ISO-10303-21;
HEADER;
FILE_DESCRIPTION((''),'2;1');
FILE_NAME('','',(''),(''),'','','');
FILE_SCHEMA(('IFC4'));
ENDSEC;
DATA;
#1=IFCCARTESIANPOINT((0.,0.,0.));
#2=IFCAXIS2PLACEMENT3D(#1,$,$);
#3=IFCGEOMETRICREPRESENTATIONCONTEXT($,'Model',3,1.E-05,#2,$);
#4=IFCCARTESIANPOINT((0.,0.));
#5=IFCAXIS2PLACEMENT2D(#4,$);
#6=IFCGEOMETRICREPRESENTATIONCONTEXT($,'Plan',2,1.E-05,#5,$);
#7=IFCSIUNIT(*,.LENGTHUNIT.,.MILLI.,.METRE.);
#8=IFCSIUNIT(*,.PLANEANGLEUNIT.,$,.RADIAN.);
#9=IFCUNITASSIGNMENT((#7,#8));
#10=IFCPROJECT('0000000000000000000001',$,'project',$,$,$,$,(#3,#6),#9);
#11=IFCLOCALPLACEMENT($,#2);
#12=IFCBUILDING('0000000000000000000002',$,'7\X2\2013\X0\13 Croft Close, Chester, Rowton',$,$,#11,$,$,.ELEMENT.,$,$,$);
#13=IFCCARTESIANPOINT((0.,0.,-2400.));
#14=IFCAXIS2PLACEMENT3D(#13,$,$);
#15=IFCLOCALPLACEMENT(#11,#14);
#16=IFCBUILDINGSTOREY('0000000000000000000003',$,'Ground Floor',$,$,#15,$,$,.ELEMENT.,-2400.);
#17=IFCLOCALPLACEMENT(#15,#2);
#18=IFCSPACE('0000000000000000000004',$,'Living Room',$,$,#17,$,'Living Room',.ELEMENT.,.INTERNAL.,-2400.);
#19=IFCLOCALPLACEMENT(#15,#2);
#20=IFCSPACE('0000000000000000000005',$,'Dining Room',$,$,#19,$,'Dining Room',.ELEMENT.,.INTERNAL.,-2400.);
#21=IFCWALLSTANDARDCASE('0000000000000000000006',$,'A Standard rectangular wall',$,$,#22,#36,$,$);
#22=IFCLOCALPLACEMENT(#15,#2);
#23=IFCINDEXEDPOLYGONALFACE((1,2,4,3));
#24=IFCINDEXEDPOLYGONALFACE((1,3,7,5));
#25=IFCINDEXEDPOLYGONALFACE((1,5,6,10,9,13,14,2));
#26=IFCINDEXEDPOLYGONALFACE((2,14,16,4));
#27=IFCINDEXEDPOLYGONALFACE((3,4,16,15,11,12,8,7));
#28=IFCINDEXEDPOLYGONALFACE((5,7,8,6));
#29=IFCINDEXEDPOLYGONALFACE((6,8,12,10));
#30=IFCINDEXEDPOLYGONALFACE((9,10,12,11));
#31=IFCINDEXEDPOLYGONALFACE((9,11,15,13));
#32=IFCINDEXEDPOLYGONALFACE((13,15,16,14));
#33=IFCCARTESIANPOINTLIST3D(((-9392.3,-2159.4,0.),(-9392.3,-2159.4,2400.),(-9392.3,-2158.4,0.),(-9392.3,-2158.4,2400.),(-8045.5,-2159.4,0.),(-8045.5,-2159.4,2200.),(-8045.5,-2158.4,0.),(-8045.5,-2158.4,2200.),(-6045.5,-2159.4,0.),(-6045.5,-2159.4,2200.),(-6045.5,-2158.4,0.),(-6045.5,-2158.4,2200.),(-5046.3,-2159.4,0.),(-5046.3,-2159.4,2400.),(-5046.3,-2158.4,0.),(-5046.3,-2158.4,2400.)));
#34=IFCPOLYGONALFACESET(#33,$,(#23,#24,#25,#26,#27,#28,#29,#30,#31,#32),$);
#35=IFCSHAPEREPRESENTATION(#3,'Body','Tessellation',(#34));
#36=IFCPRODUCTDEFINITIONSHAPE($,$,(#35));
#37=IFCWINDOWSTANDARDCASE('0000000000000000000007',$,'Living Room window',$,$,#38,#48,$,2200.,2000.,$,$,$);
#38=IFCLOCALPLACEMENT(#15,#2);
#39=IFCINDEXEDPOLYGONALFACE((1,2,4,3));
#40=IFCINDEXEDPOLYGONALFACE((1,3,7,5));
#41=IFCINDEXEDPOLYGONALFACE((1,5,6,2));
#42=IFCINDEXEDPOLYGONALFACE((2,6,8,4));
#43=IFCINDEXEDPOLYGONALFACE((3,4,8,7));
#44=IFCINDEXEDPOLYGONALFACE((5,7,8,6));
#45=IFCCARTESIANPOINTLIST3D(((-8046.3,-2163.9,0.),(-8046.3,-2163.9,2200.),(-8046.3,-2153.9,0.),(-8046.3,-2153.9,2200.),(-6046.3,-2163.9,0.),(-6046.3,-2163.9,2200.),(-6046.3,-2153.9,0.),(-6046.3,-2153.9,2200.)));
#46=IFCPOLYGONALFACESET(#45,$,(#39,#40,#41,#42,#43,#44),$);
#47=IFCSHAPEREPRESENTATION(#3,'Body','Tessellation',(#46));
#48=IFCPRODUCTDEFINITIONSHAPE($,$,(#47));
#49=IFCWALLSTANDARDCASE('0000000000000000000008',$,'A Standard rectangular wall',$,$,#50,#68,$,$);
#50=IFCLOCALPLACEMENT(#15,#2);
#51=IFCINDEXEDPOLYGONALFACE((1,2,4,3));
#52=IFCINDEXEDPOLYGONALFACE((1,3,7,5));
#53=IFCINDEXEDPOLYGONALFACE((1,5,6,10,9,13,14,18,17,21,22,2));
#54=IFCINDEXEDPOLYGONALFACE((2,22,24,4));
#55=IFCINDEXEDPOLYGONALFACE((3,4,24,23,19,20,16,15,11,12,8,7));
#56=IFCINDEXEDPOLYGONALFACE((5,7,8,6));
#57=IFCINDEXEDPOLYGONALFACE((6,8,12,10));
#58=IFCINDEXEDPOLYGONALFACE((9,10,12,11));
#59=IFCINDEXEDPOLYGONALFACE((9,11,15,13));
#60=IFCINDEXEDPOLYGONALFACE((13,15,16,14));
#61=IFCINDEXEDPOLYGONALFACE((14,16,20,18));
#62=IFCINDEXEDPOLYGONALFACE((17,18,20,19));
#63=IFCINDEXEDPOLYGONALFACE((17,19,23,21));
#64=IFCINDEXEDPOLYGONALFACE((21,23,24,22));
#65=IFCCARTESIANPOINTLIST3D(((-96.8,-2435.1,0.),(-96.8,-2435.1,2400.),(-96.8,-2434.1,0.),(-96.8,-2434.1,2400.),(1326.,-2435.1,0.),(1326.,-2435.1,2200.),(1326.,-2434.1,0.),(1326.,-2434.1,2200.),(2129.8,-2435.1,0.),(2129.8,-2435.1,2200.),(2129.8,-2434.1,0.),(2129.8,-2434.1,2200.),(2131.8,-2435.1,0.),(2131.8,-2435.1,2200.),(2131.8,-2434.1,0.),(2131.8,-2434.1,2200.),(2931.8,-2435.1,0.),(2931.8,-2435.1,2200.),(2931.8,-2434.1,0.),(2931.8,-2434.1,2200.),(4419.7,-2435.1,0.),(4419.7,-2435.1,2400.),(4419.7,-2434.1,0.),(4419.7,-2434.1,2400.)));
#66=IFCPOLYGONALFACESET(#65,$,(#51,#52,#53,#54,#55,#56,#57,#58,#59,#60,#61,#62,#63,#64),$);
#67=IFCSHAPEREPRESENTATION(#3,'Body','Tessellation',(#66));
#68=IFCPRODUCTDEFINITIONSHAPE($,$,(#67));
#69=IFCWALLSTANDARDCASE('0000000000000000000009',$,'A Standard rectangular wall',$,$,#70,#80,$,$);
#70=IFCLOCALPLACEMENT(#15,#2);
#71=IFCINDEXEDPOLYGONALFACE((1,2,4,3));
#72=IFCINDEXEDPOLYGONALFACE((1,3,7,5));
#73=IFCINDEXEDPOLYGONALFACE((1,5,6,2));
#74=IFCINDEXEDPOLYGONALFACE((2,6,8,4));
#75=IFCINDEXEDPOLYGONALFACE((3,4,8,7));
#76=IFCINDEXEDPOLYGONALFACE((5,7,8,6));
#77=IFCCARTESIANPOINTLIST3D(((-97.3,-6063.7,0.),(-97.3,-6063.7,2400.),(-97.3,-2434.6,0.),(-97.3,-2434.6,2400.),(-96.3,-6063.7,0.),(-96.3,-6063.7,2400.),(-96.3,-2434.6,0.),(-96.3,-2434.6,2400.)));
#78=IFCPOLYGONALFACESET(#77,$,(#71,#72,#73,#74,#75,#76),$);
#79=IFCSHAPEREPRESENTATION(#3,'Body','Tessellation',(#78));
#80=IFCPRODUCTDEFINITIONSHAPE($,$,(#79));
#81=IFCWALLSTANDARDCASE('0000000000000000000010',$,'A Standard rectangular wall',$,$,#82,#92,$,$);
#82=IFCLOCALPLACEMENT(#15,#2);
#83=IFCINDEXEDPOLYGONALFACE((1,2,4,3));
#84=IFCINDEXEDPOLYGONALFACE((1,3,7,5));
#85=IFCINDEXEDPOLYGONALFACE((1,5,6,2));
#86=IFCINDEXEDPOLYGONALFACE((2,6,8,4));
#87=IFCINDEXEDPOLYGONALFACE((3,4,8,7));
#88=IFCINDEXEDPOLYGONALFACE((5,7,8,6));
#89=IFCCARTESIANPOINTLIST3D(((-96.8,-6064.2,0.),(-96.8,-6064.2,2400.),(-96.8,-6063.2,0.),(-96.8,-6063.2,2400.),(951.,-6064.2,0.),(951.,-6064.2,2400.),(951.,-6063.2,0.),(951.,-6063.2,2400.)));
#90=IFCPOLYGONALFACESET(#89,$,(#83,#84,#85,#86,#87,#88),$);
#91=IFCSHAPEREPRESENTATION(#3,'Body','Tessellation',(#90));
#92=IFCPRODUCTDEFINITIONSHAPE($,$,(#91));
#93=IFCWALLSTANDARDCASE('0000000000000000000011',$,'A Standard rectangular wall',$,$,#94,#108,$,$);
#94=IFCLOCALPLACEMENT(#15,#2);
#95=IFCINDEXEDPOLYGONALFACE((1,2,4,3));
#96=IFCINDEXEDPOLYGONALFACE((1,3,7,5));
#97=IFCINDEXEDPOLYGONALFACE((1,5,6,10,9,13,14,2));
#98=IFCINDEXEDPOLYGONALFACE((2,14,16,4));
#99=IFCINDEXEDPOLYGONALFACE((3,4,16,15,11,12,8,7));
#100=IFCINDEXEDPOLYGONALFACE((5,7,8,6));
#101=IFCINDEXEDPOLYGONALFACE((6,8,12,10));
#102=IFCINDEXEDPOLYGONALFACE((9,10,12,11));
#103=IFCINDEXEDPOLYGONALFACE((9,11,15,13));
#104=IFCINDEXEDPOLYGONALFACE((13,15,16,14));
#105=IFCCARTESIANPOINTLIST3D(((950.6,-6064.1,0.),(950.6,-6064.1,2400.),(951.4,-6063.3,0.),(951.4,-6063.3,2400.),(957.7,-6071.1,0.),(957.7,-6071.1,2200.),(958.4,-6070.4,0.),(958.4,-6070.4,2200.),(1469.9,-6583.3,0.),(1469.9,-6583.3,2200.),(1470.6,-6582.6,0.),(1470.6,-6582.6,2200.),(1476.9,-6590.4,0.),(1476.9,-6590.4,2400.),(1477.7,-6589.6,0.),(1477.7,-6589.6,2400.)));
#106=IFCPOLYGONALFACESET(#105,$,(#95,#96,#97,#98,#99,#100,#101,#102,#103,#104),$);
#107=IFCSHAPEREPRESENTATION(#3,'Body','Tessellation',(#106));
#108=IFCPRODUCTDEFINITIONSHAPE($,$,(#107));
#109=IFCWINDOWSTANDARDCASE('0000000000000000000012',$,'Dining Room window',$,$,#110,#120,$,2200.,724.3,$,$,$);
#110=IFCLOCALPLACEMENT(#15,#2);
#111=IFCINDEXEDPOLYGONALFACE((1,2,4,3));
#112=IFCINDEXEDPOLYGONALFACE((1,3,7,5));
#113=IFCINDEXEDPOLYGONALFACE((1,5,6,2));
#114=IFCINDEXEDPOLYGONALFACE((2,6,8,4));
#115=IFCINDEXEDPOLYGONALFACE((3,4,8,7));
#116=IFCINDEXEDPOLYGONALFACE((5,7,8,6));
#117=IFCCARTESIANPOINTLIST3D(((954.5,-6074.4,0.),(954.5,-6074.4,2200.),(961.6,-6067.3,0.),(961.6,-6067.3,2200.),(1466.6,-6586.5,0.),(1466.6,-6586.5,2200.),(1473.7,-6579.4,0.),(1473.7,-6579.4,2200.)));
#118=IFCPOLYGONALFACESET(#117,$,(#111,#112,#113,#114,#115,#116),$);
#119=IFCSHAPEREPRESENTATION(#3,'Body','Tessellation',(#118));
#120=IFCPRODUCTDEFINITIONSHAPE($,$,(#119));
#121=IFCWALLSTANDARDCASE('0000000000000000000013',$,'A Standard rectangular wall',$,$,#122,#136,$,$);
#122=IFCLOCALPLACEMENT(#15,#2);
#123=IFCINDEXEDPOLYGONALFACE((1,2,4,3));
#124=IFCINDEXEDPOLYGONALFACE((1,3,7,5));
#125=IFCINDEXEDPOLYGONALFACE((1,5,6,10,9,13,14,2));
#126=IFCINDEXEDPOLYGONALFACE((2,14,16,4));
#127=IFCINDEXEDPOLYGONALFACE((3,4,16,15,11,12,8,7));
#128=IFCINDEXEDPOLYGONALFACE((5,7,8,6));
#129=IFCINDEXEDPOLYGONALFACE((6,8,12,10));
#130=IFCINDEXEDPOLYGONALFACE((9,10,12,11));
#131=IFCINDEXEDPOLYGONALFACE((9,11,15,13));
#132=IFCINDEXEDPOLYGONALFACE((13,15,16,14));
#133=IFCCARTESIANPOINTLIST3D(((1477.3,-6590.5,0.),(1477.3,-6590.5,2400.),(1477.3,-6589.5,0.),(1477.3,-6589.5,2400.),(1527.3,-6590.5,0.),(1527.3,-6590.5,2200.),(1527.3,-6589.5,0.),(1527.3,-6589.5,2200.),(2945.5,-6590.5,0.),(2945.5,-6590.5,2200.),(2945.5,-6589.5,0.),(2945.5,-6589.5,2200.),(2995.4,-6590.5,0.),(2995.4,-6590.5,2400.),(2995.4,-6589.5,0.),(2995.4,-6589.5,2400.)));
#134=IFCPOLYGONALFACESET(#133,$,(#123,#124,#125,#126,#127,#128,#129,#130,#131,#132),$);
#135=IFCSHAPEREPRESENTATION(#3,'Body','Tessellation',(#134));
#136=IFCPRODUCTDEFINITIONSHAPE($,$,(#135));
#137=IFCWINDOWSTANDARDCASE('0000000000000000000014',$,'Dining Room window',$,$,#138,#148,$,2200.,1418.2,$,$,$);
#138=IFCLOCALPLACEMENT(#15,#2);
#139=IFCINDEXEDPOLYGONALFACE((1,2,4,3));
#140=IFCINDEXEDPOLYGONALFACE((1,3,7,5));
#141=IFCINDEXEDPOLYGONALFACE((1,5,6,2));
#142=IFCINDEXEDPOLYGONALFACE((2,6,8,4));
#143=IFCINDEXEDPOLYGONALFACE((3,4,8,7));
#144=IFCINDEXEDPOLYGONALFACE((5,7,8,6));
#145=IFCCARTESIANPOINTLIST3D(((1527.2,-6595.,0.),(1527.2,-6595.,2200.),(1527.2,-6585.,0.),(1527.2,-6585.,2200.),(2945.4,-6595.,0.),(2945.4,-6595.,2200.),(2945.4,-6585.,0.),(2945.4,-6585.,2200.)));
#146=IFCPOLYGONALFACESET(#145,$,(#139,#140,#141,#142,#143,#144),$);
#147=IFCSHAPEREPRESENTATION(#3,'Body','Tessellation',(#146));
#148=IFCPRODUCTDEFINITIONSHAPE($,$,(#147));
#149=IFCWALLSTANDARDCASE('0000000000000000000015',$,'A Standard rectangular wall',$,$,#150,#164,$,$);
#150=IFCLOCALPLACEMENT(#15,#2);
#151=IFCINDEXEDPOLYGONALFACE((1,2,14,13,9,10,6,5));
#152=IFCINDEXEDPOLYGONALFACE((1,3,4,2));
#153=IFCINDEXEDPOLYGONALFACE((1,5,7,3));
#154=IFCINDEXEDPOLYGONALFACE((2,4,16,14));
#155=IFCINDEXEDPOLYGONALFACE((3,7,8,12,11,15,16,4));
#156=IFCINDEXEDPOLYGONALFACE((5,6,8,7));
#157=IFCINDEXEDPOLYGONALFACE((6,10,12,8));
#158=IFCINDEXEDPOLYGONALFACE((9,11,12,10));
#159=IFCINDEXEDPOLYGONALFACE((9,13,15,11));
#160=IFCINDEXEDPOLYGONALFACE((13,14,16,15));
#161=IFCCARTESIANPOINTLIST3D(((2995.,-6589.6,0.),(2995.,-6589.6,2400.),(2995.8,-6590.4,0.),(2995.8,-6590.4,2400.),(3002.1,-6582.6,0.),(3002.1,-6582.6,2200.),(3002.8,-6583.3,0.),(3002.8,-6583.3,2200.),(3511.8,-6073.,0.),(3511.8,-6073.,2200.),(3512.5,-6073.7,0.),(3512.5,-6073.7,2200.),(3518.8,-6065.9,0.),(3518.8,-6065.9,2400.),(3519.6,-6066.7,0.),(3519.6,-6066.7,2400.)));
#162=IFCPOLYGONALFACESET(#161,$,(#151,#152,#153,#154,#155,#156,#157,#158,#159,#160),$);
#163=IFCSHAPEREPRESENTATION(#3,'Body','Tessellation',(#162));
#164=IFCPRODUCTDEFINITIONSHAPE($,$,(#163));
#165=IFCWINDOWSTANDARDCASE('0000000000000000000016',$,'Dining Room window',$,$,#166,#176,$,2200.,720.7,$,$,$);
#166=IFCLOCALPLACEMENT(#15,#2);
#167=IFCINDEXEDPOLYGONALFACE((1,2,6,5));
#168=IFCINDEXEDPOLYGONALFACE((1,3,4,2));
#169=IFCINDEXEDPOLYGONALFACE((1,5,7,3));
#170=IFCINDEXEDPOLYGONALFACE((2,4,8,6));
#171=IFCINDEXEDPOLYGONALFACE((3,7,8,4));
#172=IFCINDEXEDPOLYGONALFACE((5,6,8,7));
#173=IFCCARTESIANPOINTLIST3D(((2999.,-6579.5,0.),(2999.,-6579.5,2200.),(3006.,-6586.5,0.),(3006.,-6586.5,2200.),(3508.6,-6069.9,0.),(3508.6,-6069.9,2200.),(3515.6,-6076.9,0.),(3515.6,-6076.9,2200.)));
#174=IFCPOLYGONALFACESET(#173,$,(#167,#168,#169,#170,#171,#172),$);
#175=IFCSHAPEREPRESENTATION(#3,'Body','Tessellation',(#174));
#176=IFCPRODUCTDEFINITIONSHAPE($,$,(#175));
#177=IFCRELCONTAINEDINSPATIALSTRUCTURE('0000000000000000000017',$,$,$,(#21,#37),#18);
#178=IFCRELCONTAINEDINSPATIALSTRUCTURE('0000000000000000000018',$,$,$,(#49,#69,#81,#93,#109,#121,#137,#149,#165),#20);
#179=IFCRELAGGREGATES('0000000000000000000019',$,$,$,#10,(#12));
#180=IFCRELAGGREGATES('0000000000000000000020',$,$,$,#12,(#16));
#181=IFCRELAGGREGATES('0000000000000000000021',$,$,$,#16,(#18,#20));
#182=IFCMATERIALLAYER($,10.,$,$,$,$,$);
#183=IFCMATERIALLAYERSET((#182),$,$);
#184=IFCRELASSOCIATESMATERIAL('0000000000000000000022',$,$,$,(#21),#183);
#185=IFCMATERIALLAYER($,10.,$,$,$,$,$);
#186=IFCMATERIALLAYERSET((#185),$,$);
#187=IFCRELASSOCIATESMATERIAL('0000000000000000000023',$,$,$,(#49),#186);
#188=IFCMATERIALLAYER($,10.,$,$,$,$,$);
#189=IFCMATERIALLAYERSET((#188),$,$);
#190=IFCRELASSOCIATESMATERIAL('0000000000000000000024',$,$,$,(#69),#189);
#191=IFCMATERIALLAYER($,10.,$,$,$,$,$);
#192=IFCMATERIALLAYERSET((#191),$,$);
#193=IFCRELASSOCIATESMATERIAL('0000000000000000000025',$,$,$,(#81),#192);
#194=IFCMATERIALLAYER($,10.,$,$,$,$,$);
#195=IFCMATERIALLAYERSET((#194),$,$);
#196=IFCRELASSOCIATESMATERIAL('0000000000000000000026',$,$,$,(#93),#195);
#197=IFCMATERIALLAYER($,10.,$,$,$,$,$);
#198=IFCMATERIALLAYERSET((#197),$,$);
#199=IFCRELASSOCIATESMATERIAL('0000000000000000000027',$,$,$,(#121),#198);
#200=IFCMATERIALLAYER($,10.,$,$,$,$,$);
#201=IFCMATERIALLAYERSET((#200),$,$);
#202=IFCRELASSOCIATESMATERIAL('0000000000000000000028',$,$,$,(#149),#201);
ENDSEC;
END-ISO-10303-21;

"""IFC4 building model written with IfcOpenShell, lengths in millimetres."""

from ifc_helpers import new_model, si_unit, frame, origin, origin_2d, place, context, project, spatial, rectangle, extrude, layer, layer_set, layer_usage, element, fill, save


model = new_model("IFC4")

# Units and contexts
model_context = context("Model", 3, precision=1e-05, world=origin())
plan_context = context("Plan", 2, precision=1e-05, world=origin_2d())
ifc_project = project(units=[si_unit("LENGTHUNIT", "METRE", prefix="MILLI"), si_unit("PLANEANGLEUNIT", "RADIAN")], contexts=[model_context, plan_context])

# Building, storey, space
building_placement = place(None, origin())
building = spatial("IfcBuilding", under=ifc_project, at=building_placement, Name="7–13 Croft Close, Chester, Rowton", CompositionType="ELEMENT")
storey_placement = place(building_placement, frame((0.0, 0.0, -2400.0)))
storey = spatial("IfcBuildingStorey", under=building, at=storey_placement, Name="Ground Floor", CompositionType="ELEMENT", Elevation=-2400.0)
space_1_placement = place(storey_placement, origin())
space_1 = spatial("IfcSpace", under=storey, at=space_1_placement, Name="Living Room", LongName="Living Room", CompositionType="ELEMENT", PredefinedType="INTERNAL", ElevationWithFlooring=-2400.0)

# Shared definitions
space_2_placement = place(storey_placement, origin())
space_2 = spatial("IfcSpace", under=storey, at=space_2_placement, Name="Dining Room", LongName="Dining Room", CompositionType="ELEMENT", PredefinedType="INTERNAL", ElevationWithFlooring=-2400.0)

# Wall, opening, window
ifc_layer_1 = layer(None, 10.0)
ifc_layer_set_1 = layer_set([ifc_layer_1])
ifc_layer_usage_1 = layer_usage(ifc_layer_set_1, "AXIS2", "NEGATIVE", 150.0)
wall_1_placement = place(storey_placement, origin())
wall_1 = element("IfcWallStandardCase", 1, at=wall_1_placement, inside=space_1, material=ifc_layer_usage_1, Name="A Standard rectangular wall", context=model_context, shape_type="SweptSolid", body=[
    extrude(rectangle(XDim=1.0, YDim=4346.0, at=origin_2d()), frame((-7219.3, -2158.9, 0.0), x_axis=(0.0, 1.0, 0.0)), (0.0, 0.0, 1.0), 2400.0),
])
opening_1_placement = place(storey_placement, origin())
opening_1 = element("IfcOpeningElement", 2, at=opening_1_placement, cuts=wall_1, context=model_context, shape_type="SweptSolid", body=[
    extrude(rectangle(XDim=10.0, YDim=2000.0, at=origin_2d()), frame((-7045.5, -2158.9, 0.0), x_axis=(0.0, 1.0, 0.0)), (0.0, 0.0, 1.0), 2200.0),
])
window_1_placement = place(storey_placement, frame((-0.8, 0.0, 0.0)))
window_1 = element("IfcWindowStandardCase", 3, at=window_1_placement, inside=space_1, Name="Living Room window", OverallHeight=2200.0, OverallWidth=2000.0, context=model_context, shape_type="SweptSolid", body=[
    extrude(rectangle(XDim=10.0, YDim=2000.0, at=origin_2d()), frame((-7045.5, -2158.9, 0.0), x_axis=(0.0, 1.0, 0.0)), (0.0, 0.0, 1.0), 2200.0),
])
fill(opening_1, window_1)

# Wall, openings
ifc_layer_2 = layer(None, 10.0)
ifc_layer_set_2 = layer_set([ifc_layer_2])
ifc_layer_usage_2 = layer_usage(ifc_layer_set_2, "AXIS2", "NEGATIVE", 150.0)
wall_2_placement = place(storey_placement, origin())
wall_2 = element("IfcWallStandardCase", 4, at=wall_2_placement, inside=space_2, material=ifc_layer_usage_2, Name="A Standard rectangular wall", context=model_context, shape_type="SweptSolid", body=[
    extrude(rectangle(XDim=1.0, YDim=4516.5, at=origin_2d()), frame((2161.5, -2434.6, 0.0), x_axis=(0.0, -1.0, 0.0)), (0.0, 0.0, 1.0), 2400.0),
])
opening_2_placement = place(storey_placement, origin())
element("IfcOpeningElement", 5, at=opening_2_placement, cuts=wall_2, context=model_context, shape_type="SweptSolid", body=[
    extrude(rectangle(XDim=10.0, YDim=800.0, at=origin_2d()), frame((2531.8, -2434.6, 0.0), x_axis=(0.0, 1.0, 0.0)), (0.0, 0.0, 1.0), 2200.0),
])
opening_3_placement = place(storey_placement, origin())
element("IfcOpeningElement", 6, at=opening_3_placement, cuts=wall_2, context=model_context, shape_type="SweptSolid", body=[
    extrude(rectangle(XDim=10.0, YDim=803.8, at=origin_2d()), frame((1727.9, -2434.6, 0.0), x_axis=(0.0, 1.0, 0.0)), (0.0, 0.0, 1.0), 2200.0),
])

# Walls
ifc_layer_3 = layer(None, 10.0)
ifc_layer_set_3 = layer_set([ifc_layer_3])
ifc_layer_usage_3 = layer_usage(ifc_layer_set_3, "AXIS2", "NEGATIVE", 150.0)
wall_3_placement = place(storey_placement, origin())
element("IfcWallStandardCase", 7, at=wall_3_placement, inside=space_2, material=ifc_layer_usage_3, Name="A Standard rectangular wall", context=model_context, shape_type="SweptSolid", body=[
    extrude(rectangle(XDim=1.0, YDim=3629.1, at=origin_2d()), frame((-96.8, -4249.2, 0.0), x_axis=(1.0, 0.0, 0.0)), (0.0, 0.0, 1.0), 2400.0),
])
ifc_layer_4 = layer(None, 10.0)
ifc_layer_set_4 = layer_set([ifc_layer_4])
ifc_layer_usage_4 = layer_usage(ifc_layer_set_4, "AXIS2", "NEGATIVE", 150.0)
wall_4_placement = place(storey_placement, origin())
element("IfcWallStandardCase", 8, at=wall_4_placement, inside=space_2, material=ifc_layer_usage_4, Name="A Standard rectangular wall", context=model_context, shape_type="SweptSolid", body=[
    extrude(rectangle(XDim=1.0, YDim=1047.8, at=origin_2d()), frame((427.1, -6063.7, 0.0), x_axis=(0.0, 1.0, 0.0)), (0.0, 0.0, 1.0), 2400.0),
])

# Walls, openings, windows
ifc_layer_5 = layer(None, 10.0)
ifc_layer_set_5 = layer_set([ifc_layer_5])
ifc_layer_usage_5 = layer_usage(ifc_layer_set_5, "AXIS2", "NEGATIVE", 150.0)
wall_5_placement = place(storey_placement, origin())
wall_5 = element("IfcWallStandardCase", 9, at=wall_5_placement, inside=space_2, material=ifc_layer_usage_5, Name="A Standard rectangular wall", context=model_context, shape_type="SweptSolid", body=[
    extrude(rectangle(XDim=1.0, YDim=744.3, at=origin_2d()), frame((1214.2, -6326.9, 0.0), x_axis=(0.707107, 0.707107, 0.0)), (0.0, 0.0, 1.0), 2400.0),
])
opening_4_placement = place(storey_placement, origin())
opening_4 = element("IfcOpeningElement", 10, at=opening_4_placement, cuts=wall_5, context=model_context, shape_type="SweptSolid", body=[
    extrude(rectangle(XDim=10.0, YDim=724.3, at=origin_2d()), frame((1214.1, -6326.8, 0.0), x_axis=(0.707107, 0.707107, 0.0)), (0.0, 0.0, 1.0), 2200.0),
])
window_2_placement = place(storey_placement, frame((0.0, -0.1, 0.0)))
window_2 = element("IfcWindowStandardCase", 11, at=window_2_placement, inside=space_2, Name="Dining Room window", OverallHeight=2200.0, OverallWidth=724.3, context=model_context, shape_type="SweptSolid", body=[
    extrude(rectangle(XDim=10.0, YDim=724.3, at=origin_2d()), frame((1214.1, -6326.8, 0.0), x_axis=(0.707107, 0.707107, 0.0)), (0.0, 0.0, 1.0), 2200.0),
])
fill(opening_4, window_2)
ifc_layer_6 = layer(None, 10.0)
ifc_layer_set_6 = layer_set([ifc_layer_6])
ifc_layer_usage_6 = layer_usage(ifc_layer_set_6, "AXIS2", "NEGATIVE", 150.0)
wall_6_placement = place(storey_placement, origin())
wall_6 = element("IfcWallStandardCase", 12, at=wall_6_placement, inside=space_2, material=ifc_layer_usage_6, Name="A Standard rectangular wall", context=model_context, shape_type="SweptSolid", body=[
    extrude(rectangle(XDim=1.0, YDim=1518.1, at=origin_2d()), frame((2236.4, -6590.0, 0.0), x_axis=(0.0, 1.0, 0.0)), (0.0, 0.0, 1.0), 2400.0),
])
opening_5_placement = place(storey_placement, origin())
opening_5 = element("IfcOpeningElement", 13, at=opening_5_placement, cuts=wall_6, context=model_context, shape_type="SweptSolid", body=[
    extrude(rectangle(XDim=10.0, YDim=1418.2, at=origin_2d()), frame((2236.4, -6590.0, 0.0), x_axis=(0.0, 1.0, 0.0)), (0.0, 0.0, 1.0), 2200.0),
])
window_3_placement = place(storey_placement, frame((-0.1, 0.0, 0.0)))
window_3 = element("IfcWindowStandardCase", 14, at=window_3_placement, inside=space_2, Name="Dining Room window", OverallHeight=2200.0, OverallWidth=1418.2, context=model_context, shape_type="SweptSolid", body=[
    extrude(rectangle(XDim=10.0, YDim=1418.2, at=origin_2d()), frame((2236.4, -6590.0, 0.0), x_axis=(0.0, 1.0, 0.0)), (0.0, 0.0, 1.0), 2200.0),
])
fill(opening_5, window_3)
ifc_layer_7 = layer(None, 10.0)
ifc_layer_set_7 = layer_set([ifc_layer_7])
ifc_layer_usage_7 = layer_usage(ifc_layer_set_7, "AXIS2", "NEGATIVE", 150.0)
wall_7_placement = place(storey_placement, origin())
wall_7 = element("IfcWallStandardCase", 15, at=wall_7_placement, inside=space_2, material=ifc_layer_usage_7, Name="A Standard rectangular wall", context=model_context, shape_type="SweptSolid", body=[
    extrude(rectangle(XDim=1.0, YDim=740.7, at=origin_2d()), frame((3257.3, -6328.1, 0.0), x_axis=(-0.707039, 0.707174, 0.0)), (0.0, 0.0, 1.0), 2400.0),
])
opening_6_placement = place(storey_placement, origin())
opening_6 = element("IfcOpeningElement", 16, at=opening_6_placement, cuts=wall_7, context=model_context, shape_type="SweptSolid", body=[
    extrude(rectangle(XDim=10.0, YDim=720.7, at=origin_2d()), frame((3257.3, -6328.1, 0.0), x_axis=(-0.707107, 0.707107, 0.0)), (0.0, 0.0, 1.0), 2200.0),
])
window_4_placement = place(storey_placement, frame((0.0, -0.1, 0.0)))
window_4 = element("IfcWindowStandardCase", 17, at=window_4_placement, inside=space_2, Name="Dining Room window", OverallHeight=2200.0, OverallWidth=720.7, context=model_context, shape_type="SweptSolid", body=[
    extrude(rectangle(XDim=10.0, YDim=720.7, at=origin_2d()), frame((3257.3, -6328.1, 0.0), x_axis=(-0.707107, 0.707107, 0.0)), (0.0, 0.0, 1.0), 2200.0),
])
fill(opening_6, window_4)

save(model, "model.ifc")
